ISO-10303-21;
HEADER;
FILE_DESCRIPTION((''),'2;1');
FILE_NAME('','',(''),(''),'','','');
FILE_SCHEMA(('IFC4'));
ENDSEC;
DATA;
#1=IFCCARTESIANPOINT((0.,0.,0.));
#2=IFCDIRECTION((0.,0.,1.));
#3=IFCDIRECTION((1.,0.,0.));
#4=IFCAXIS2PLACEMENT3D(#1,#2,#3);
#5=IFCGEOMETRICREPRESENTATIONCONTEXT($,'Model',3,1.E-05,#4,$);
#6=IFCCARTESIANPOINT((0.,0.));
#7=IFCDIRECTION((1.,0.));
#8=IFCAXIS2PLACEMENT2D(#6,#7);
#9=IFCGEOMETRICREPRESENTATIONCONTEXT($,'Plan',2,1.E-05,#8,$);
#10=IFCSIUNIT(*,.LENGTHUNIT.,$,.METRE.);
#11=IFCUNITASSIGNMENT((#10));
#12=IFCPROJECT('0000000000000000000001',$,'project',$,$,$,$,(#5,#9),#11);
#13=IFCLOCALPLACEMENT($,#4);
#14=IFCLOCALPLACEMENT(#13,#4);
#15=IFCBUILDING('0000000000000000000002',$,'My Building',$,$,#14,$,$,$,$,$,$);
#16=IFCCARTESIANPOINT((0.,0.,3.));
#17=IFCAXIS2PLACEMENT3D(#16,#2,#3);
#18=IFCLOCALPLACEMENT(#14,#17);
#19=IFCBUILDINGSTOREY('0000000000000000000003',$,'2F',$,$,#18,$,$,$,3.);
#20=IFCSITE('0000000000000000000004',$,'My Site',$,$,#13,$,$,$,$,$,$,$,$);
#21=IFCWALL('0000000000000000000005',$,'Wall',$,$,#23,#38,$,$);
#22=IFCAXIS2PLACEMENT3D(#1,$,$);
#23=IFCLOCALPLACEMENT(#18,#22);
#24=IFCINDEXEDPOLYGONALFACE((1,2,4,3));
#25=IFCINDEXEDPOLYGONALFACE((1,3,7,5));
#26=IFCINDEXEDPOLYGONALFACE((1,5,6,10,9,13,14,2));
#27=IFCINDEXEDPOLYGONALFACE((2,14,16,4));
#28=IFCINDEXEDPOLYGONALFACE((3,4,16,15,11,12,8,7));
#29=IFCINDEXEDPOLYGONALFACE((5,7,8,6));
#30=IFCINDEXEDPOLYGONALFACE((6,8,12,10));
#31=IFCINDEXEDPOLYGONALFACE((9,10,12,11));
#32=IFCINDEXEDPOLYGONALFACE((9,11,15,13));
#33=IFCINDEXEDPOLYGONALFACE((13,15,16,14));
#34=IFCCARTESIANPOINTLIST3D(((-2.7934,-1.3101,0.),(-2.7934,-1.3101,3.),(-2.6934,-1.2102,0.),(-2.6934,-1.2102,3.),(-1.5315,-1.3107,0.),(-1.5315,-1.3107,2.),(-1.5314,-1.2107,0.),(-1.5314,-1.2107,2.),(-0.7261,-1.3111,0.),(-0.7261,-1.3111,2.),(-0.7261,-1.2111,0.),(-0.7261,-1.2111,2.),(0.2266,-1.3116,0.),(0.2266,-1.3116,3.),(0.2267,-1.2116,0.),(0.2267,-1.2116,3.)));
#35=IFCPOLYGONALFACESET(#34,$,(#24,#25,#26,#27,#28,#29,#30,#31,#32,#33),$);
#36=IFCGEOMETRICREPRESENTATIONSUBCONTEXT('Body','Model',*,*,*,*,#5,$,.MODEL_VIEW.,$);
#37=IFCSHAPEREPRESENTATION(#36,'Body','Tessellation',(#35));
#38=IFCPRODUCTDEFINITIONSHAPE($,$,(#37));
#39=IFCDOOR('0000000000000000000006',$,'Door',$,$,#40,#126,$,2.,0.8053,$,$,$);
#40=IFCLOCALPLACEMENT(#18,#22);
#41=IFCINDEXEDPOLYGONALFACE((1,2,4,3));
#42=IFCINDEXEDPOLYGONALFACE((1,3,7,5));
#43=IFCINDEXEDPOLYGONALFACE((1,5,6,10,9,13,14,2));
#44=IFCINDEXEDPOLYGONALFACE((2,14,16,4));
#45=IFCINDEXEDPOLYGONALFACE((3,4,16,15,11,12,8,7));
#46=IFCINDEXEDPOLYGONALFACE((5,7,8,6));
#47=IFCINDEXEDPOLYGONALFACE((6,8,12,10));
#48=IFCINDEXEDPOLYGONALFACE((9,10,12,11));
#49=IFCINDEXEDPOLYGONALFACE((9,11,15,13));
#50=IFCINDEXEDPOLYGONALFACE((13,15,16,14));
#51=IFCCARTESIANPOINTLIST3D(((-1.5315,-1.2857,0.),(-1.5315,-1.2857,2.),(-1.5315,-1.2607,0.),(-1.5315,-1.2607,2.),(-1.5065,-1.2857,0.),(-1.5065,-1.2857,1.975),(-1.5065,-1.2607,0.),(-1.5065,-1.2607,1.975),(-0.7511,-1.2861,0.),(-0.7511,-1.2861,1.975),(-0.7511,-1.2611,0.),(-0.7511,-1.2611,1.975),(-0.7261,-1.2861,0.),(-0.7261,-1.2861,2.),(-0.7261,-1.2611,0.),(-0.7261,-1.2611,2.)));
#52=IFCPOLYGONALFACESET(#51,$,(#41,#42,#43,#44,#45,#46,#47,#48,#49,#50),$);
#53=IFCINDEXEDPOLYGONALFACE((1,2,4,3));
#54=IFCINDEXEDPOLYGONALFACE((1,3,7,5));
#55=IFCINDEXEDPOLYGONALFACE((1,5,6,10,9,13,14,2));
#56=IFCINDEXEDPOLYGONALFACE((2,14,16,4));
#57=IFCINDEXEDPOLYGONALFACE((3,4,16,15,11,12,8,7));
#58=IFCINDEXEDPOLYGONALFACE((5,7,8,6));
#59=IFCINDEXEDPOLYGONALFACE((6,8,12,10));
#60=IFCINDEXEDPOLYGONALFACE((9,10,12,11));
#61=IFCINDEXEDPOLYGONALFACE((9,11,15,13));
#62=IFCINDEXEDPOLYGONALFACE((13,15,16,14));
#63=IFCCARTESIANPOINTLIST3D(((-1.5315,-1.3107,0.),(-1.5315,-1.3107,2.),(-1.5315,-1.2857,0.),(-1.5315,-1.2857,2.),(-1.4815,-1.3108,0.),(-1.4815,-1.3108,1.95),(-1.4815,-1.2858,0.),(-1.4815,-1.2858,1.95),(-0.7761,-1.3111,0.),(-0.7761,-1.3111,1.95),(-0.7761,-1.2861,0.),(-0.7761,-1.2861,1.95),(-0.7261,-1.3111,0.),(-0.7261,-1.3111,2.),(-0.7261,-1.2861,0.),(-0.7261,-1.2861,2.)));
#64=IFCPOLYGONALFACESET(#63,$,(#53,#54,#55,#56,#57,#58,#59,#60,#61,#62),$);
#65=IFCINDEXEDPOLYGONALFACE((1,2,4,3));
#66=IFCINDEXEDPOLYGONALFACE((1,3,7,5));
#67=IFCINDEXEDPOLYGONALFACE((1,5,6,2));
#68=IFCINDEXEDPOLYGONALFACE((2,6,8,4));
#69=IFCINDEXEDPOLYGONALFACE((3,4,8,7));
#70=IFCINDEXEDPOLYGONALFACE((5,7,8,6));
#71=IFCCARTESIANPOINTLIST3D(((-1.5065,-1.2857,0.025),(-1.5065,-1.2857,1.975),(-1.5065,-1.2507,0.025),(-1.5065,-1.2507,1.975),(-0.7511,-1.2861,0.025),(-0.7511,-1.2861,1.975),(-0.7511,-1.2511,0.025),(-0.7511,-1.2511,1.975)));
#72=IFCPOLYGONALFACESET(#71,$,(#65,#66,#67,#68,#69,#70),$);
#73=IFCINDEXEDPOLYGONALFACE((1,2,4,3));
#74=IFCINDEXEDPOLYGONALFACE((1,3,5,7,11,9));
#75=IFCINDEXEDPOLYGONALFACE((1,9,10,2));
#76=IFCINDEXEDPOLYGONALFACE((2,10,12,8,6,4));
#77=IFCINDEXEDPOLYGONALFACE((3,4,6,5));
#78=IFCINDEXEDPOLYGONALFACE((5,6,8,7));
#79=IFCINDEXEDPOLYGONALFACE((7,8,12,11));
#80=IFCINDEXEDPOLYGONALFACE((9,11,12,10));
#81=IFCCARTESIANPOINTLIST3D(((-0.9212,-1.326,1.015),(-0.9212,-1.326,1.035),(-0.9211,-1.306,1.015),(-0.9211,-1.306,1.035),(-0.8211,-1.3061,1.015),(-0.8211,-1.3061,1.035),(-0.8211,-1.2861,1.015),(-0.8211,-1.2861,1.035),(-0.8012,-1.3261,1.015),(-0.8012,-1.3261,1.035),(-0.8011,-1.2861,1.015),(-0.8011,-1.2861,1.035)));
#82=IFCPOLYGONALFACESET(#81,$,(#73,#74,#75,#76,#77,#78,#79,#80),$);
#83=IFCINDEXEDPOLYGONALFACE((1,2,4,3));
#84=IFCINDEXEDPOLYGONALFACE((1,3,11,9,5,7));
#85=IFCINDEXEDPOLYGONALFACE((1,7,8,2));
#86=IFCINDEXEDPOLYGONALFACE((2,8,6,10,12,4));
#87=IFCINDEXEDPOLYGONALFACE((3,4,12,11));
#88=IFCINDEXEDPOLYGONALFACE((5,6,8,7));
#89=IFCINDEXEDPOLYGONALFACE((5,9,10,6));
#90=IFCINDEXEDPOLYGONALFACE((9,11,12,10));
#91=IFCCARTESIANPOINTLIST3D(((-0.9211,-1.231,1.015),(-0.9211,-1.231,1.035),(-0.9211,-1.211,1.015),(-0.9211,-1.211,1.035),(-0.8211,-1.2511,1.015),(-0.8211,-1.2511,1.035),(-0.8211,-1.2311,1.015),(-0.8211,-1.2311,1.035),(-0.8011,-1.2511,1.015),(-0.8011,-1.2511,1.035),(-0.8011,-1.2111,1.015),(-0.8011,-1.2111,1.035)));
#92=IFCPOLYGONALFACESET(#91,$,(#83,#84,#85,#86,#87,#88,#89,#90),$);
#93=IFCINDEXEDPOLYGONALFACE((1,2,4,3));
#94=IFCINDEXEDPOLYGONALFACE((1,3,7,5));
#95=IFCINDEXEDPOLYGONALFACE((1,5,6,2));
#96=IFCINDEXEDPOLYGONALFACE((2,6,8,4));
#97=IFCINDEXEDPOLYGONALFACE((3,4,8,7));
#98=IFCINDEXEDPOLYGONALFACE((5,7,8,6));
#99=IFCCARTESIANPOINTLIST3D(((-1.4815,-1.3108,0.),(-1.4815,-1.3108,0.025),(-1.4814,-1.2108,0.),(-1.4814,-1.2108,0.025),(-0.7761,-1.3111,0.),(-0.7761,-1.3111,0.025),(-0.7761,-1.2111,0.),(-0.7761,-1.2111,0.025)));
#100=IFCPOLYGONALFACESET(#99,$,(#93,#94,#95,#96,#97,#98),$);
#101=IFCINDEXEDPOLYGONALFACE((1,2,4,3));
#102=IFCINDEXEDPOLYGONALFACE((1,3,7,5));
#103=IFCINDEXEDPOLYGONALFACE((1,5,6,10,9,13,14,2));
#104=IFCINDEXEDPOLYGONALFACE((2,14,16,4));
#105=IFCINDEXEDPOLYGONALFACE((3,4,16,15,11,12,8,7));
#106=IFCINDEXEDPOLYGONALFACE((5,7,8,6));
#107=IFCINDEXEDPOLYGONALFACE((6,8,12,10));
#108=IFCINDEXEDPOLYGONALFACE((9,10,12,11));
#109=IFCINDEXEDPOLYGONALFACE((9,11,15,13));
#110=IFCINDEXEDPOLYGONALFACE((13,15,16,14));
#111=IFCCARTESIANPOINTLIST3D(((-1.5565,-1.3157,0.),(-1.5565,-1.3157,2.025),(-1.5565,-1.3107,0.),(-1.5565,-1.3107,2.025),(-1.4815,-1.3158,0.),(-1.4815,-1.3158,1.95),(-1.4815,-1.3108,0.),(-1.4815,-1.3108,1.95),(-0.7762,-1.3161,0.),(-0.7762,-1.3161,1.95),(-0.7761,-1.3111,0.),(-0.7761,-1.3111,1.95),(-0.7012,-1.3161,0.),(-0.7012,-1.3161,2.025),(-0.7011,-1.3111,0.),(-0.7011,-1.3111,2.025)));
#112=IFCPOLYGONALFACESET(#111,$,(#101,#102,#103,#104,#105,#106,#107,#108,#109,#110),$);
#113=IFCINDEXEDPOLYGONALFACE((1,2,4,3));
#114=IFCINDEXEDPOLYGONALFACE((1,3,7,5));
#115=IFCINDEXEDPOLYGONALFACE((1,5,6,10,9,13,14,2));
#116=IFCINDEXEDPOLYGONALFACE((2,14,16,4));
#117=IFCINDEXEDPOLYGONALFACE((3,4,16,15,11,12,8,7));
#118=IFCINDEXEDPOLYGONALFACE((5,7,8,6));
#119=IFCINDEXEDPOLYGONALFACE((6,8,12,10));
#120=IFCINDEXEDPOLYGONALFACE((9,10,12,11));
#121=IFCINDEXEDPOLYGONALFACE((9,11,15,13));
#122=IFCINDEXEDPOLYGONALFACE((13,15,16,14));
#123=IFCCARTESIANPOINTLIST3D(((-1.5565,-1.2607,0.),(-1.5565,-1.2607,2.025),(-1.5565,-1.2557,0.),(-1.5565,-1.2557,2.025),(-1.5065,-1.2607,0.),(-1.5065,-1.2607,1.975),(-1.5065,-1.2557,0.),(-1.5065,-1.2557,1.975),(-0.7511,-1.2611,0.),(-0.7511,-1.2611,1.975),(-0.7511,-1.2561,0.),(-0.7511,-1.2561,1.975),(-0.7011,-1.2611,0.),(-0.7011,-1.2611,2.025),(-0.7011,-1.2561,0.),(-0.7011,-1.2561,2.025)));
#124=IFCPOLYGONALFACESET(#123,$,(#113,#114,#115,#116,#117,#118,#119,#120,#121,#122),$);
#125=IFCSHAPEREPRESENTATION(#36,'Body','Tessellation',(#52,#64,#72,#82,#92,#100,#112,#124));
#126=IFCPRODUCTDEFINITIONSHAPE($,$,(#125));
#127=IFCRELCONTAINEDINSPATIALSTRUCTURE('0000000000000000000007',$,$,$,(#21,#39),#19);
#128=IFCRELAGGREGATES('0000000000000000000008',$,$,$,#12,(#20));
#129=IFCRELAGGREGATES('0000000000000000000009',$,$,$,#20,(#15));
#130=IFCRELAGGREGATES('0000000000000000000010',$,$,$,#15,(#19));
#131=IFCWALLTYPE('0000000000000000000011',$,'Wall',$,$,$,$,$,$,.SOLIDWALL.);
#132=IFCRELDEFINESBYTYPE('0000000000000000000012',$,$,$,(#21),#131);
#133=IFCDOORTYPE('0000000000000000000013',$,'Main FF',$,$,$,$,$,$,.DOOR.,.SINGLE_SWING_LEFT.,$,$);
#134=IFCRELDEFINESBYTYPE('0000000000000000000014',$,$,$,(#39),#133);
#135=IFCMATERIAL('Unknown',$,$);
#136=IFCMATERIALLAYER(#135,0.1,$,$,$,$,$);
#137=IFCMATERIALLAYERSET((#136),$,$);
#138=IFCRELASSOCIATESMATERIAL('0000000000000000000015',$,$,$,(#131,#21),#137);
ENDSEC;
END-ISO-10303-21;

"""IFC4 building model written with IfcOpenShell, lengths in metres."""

from ifc_helpers import new_model, entity, si_unit, frame, origin_with_axes, origin_2d_with_axis, place, context, subcontext, project, spatial, line, indexed_curve, outline, extrude, shape, source, transform, mapped, material, layer, layer_set, layer_usage, type_object, type_shapes, element, fill, save


model = new_model("IFC4")

# Units and contexts
model_context = context("Model", 3, precision=1e-05, world=origin_with_axes())
plan_context = context("Plan", 2, precision=1e-05, world=origin_2d_with_axis())
body_context_1 = subcontext(model_context, "Body", "Model", "MODEL_VIEW")
body_context_2 = subcontext(plan_context, "Body", "Plan", "PLAN_VIEW")
ifc_project = project(units=[si_unit("LENGTHUNIT", "METRE")], contexts=[model_context, plan_context])

# Site, building, storey
site_placement = place(None, origin_with_axes())
site = spatial("IfcSite", under=ifc_project, at=site_placement, Name="My Site")
building_placement = place(site_placement, origin_with_axes())
building = spatial("IfcBuilding", under=site, at=building_placement, Name="My Building")
storey_placement = place(building_placement, frame((0.0, 0.0, 3.0), z_axis=(0.0, 0.0, 1.0), x_axis=(1.0, 0.0, 0.0)))
storey = spatial("IfcBuildingStorey", under=building, at=storey_placement, Name="2F", Elevation=3.0)

# Shared definitions
ifc_material = material(Name="Unknown")

# Shared definitions
ifc_layer_1 = layer(ifc_material, 0.1)
ifc_layer_set_1 = layer_set([ifc_layer_1])
wall_type = type_object("IfcWallType", Name="Wall", PredefinedType="SOLIDWALL", material=ifc_layer_set_1)

# Wall, opening, door
ifc_layer_usage_1 = layer_usage(ifc_layer_set_1, "AXIS2", "POSITIVE", 0.0)
wall_1_placement = place(storey_placement, frame((-2.7934, -1.3101, 0.0), z_axis=(0.0, 0.0, 1.0), x_axis=(1.0, -0.000494, 0.0)))
wall_1 = element("IfcWall", 1, at=wall_1_placement, inside=storey, type_object=wall_type, material=ifc_layer_usage_1, Name="Wall", context=body_context_1, shape_type="SweptSolid", body=[
    extrude(outline(indexed_curve([(0.0, 0.0), (0.1, 0.1), (3.02, 0.1), (3.02, 0.0)], segments=[line(1, 2, 3, 4, 1)])), origin_with_axes(), (0.0, 0.0, 1.0), 3.0),
])
shared_shape_1 = source(origin_with_axes(), body_context_1, "Body", "SweptSolid", [
    extrude(outline(indexed_curve([(0.0, 0.0), (0.8053, 0.0), (0.8053, 2.0), (0.0, 2.0)], segments=[line(1, 2, 3, 4, 1)])), frame((0.0, -0.6, 0.0), z_axis=(0.0, -1.0, 0.0), x_axis=(1.0, 0.0, 0.0)), (0.0, 0.0, -1.0), 1.2),
])
opening_1_placement = place(wall_1_placement, frame((1.2619, 0.0, 0.0), z_axis=(0.0, 0.0, 1.0), x_axis=(1.0, 0.0, 0.0)))
opening_1 = element("IfcOpeningElement", 2, at=opening_1_placement, cuts=wall_1, PredefinedType="OPENING", context=body_context_1, shape_type="MappedRepresentation", body=[
    mapped(shared_shape_1, transform((0.0, 0.0, 0.0), x_axis=(1.0, 0.0, 0.0), y_axis=(0.0, 1.0, 0.0), z_axis=(0.0, 0.0, 1.0), scale=1.0)),
])
door_type_1 = type_object("IfcDoorType", Name="Main FF", OperationType="SINGLE_SWING_LEFT", PredefinedType="DOOR")
shared_shape_2 = source(origin_with_axes(), body_context_1, "Body", "SweptSolid", [
    extrude(outline(indexed_curve([(0.0, 0.0), (0.0, 2.0), (0.8053, 2.0), (0.8053, 0.0), (0.7803, 0.0), (0.7803, 1.975), (0.025, 1.975), (0.025, 0.0)], segments=[line(1, 2, 3, 4, 5, 6, 7, 8, 1)])), frame((0.0, 0.025, 0.0), z_axis=(0.0, -1.0, 0.0), x_axis=(1.0, 0.0, 0.0)), (0.0, 0.0, -1.0), 0.025),
    extrude(outline(indexed_curve([(0.0, 0.0), (0.0, 2.0), (0.8053, 2.0), (0.8053, 0.0), (0.7553, 0.0), (0.7553, 1.95), (0.05, 1.95), (0.05, 0.0)], segments=[line(1, 2, 3, 4, 5, 6, 7, 8, 1)])), frame((0.0, 0.0, 0.0), z_axis=(0.0, -1.0, 0.0), x_axis=(1.0, 0.0, 0.0)), (0.0, 0.0, -1.0), 0.025),
    extrude(outline(indexed_curve([(0.0, 0.0), (0.7553, 0.0), (0.7553, 0.035), (0.0, 0.035)], segments=[line(1, 2, 3, 4, 1)])), frame((0.025, 0.025, 0.025), z_axis=(0.0, 0.0, 1.0), x_axis=(1.0, 0.0, 0.0)), (0.0, 0.0, 1.0), 1.95),
    extrude(outline(indexed_curve([(0.0, 0.0), (0.0, -0.04), (-0.12, -0.04), (-0.12, -0.02), (-0.02, -0.02), (-0.02, 0.0)], segments=[line(1, 2, 3, 4, 5, 6, 1)])), frame((0.7303, 0.025, 1.015), z_axis=(0.0, 0.0, 1.0), x_axis=(1.0, 0.0, 0.0)), (0.0, 0.0, 1.0), 0.02),
    extrude(outline(indexed_curve([(0.0, 0.0), (0.0, 0.04), (-0.12, 0.04), (-0.12, 0.02), (-0.02, 0.02), (-0.02, 0.0)], segments=[line(1, 2, 3, 4, 5, 6, 1)])), frame((0.7303, 0.06, 1.015), z_axis=(0.0, 0.0, 1.0), x_axis=(1.0, 0.0, 0.0)), (0.0, 0.0, 1.0), 0.02),
    extrude(outline(indexed_curve([(0.0, 0.0), (0.7053, 0.0), (0.7053, 0.1), (0.0, 0.1)], segments=[line(1, 2, 3, 4, 1)])), frame((0.05, 0.0, 0.0), z_axis=(0.0, 0.0, 1.0), x_axis=(1.0, 0.0, 0.0)), (0.0, 0.0, 1.0), 0.025),
    extrude(outline(indexed_curve([(0.0, 0.0), (0.0, 2.025), (0.8553, 2.025), (0.8553, 0.0), (0.7803, 0.0), (0.7803, 1.95), (0.075, 1.95), (0.075, 0.0)], segments=[line(1, 2, 3, 4, 5, 6, 7, 8, 1)])), frame((-0.025, -0.005, 0.0), z_axis=(0.0, -1.0, 0.0), x_axis=(1.0, 0.0, 0.0)), (0.0, 0.0, -1.0), 0.005),
    extrude(outline(indexed_curve([(0.0, 0.0), (0.0, 2.025), (0.8553, 2.025), (0.8553, 0.0), (0.8053, 0.0), (0.8053, 1.975), (0.05, 1.975), (0.05, 0.0)], segments=[line(1, 2, 3, 4, 5, 6, 7, 8, 1)])), frame((-0.025, 0.05, 0.0), z_axis=(0.0, -1.0, 0.0), x_axis=(1.0, 0.0, 0.0)), (0.0, 0.0, -1.0), 0.005),
])
shared_shape_3 = source(origin_with_axes(), body_context_2, "Body", "Curve2D", [
    entity("IfcIndexedPolyCurve", entity("IfcCartesianPointList2D", [[0.0, 0.0], [0.0, 0.05], [0.025, 0.05], [0.025, 0.025], [0.05, 0.025], [0.05, 0.0]]), [entity("IfcLineIndex", [1, 2, 3, 4, 5, 6, 1])]),
    entity("IfcIndexedPolyCurve", entity("IfcCartesianPointList2D", [[0.8053, 0.0], [0.8053, 0.05], [0.7803, 0.05], [0.7803, 0.025], [0.7553, 0.025], [0.7553, 0.0]]), [entity("IfcLineIndex", [1, 2, 3, 4, 5, 6, 1])]),
    entity("IfcTrimmedCurve", entity("IfcEllipse", entity("IfcAxis2Placement2D", entity("IfcCartesianPoint", [0.06, 0.05]), entity("IfcDirection", [1.0, 0.0])), 0.7203, 0.7553), [entity("IfcCartesianPoint", [0.7803, 0.05])], [entity("IfcCartesianPoint", [0.06, 0.8053])], True, "CARTESIAN"),
    entity("IfcIndexedPolyCurve", entity("IfcCartesianPointList2D", [[0.025, 0.05], [0.06, 0.05], [0.06, 0.8053], [0.025, 0.8053]]), [entity("IfcLineIndex", [1, 2, 3, 4, 1])]),
])
type_shapes(door_type_1, [shared_shape_2, shared_shape_3])
door_1_placement = place(opening_1_placement, frame((0.0, 0.0, 0.0), z_axis=(0.0, 0.0, 1.0), x_axis=(1.0, 0.0, 0.0)))
door_1 = element("IfcDoor", 3, at=door_1_placement, inside=storey, type_object=door_type_1, Name="Door", OverallHeight=2.0, OverallWidth=0.8053, shapes=[
    shape(body_context_1, "Body", "MappedRepresentation", [mapped(shared_shape_2, transform((0.0, 0.0, 0.0), x_axis=(1.0, 0.0, 0.0), y_axis=(0.0, 1.0, 0.0), z_axis=(0.0, 0.0, 1.0), scale=1.0))]),
    shape(body_context_2, "Body", "MappedRepresentation", [mapped(shared_shape_3, transform((0.0, 0.0, 0.0), x_axis=(1.0, 0.0, 0.0), y_axis=(0.0, 1.0, 0.0), z_axis=(0.0, 0.0, 1.0), scale=1.0))]),
])
fill(opening_1, door_1)

save(model, "model.ifc")
